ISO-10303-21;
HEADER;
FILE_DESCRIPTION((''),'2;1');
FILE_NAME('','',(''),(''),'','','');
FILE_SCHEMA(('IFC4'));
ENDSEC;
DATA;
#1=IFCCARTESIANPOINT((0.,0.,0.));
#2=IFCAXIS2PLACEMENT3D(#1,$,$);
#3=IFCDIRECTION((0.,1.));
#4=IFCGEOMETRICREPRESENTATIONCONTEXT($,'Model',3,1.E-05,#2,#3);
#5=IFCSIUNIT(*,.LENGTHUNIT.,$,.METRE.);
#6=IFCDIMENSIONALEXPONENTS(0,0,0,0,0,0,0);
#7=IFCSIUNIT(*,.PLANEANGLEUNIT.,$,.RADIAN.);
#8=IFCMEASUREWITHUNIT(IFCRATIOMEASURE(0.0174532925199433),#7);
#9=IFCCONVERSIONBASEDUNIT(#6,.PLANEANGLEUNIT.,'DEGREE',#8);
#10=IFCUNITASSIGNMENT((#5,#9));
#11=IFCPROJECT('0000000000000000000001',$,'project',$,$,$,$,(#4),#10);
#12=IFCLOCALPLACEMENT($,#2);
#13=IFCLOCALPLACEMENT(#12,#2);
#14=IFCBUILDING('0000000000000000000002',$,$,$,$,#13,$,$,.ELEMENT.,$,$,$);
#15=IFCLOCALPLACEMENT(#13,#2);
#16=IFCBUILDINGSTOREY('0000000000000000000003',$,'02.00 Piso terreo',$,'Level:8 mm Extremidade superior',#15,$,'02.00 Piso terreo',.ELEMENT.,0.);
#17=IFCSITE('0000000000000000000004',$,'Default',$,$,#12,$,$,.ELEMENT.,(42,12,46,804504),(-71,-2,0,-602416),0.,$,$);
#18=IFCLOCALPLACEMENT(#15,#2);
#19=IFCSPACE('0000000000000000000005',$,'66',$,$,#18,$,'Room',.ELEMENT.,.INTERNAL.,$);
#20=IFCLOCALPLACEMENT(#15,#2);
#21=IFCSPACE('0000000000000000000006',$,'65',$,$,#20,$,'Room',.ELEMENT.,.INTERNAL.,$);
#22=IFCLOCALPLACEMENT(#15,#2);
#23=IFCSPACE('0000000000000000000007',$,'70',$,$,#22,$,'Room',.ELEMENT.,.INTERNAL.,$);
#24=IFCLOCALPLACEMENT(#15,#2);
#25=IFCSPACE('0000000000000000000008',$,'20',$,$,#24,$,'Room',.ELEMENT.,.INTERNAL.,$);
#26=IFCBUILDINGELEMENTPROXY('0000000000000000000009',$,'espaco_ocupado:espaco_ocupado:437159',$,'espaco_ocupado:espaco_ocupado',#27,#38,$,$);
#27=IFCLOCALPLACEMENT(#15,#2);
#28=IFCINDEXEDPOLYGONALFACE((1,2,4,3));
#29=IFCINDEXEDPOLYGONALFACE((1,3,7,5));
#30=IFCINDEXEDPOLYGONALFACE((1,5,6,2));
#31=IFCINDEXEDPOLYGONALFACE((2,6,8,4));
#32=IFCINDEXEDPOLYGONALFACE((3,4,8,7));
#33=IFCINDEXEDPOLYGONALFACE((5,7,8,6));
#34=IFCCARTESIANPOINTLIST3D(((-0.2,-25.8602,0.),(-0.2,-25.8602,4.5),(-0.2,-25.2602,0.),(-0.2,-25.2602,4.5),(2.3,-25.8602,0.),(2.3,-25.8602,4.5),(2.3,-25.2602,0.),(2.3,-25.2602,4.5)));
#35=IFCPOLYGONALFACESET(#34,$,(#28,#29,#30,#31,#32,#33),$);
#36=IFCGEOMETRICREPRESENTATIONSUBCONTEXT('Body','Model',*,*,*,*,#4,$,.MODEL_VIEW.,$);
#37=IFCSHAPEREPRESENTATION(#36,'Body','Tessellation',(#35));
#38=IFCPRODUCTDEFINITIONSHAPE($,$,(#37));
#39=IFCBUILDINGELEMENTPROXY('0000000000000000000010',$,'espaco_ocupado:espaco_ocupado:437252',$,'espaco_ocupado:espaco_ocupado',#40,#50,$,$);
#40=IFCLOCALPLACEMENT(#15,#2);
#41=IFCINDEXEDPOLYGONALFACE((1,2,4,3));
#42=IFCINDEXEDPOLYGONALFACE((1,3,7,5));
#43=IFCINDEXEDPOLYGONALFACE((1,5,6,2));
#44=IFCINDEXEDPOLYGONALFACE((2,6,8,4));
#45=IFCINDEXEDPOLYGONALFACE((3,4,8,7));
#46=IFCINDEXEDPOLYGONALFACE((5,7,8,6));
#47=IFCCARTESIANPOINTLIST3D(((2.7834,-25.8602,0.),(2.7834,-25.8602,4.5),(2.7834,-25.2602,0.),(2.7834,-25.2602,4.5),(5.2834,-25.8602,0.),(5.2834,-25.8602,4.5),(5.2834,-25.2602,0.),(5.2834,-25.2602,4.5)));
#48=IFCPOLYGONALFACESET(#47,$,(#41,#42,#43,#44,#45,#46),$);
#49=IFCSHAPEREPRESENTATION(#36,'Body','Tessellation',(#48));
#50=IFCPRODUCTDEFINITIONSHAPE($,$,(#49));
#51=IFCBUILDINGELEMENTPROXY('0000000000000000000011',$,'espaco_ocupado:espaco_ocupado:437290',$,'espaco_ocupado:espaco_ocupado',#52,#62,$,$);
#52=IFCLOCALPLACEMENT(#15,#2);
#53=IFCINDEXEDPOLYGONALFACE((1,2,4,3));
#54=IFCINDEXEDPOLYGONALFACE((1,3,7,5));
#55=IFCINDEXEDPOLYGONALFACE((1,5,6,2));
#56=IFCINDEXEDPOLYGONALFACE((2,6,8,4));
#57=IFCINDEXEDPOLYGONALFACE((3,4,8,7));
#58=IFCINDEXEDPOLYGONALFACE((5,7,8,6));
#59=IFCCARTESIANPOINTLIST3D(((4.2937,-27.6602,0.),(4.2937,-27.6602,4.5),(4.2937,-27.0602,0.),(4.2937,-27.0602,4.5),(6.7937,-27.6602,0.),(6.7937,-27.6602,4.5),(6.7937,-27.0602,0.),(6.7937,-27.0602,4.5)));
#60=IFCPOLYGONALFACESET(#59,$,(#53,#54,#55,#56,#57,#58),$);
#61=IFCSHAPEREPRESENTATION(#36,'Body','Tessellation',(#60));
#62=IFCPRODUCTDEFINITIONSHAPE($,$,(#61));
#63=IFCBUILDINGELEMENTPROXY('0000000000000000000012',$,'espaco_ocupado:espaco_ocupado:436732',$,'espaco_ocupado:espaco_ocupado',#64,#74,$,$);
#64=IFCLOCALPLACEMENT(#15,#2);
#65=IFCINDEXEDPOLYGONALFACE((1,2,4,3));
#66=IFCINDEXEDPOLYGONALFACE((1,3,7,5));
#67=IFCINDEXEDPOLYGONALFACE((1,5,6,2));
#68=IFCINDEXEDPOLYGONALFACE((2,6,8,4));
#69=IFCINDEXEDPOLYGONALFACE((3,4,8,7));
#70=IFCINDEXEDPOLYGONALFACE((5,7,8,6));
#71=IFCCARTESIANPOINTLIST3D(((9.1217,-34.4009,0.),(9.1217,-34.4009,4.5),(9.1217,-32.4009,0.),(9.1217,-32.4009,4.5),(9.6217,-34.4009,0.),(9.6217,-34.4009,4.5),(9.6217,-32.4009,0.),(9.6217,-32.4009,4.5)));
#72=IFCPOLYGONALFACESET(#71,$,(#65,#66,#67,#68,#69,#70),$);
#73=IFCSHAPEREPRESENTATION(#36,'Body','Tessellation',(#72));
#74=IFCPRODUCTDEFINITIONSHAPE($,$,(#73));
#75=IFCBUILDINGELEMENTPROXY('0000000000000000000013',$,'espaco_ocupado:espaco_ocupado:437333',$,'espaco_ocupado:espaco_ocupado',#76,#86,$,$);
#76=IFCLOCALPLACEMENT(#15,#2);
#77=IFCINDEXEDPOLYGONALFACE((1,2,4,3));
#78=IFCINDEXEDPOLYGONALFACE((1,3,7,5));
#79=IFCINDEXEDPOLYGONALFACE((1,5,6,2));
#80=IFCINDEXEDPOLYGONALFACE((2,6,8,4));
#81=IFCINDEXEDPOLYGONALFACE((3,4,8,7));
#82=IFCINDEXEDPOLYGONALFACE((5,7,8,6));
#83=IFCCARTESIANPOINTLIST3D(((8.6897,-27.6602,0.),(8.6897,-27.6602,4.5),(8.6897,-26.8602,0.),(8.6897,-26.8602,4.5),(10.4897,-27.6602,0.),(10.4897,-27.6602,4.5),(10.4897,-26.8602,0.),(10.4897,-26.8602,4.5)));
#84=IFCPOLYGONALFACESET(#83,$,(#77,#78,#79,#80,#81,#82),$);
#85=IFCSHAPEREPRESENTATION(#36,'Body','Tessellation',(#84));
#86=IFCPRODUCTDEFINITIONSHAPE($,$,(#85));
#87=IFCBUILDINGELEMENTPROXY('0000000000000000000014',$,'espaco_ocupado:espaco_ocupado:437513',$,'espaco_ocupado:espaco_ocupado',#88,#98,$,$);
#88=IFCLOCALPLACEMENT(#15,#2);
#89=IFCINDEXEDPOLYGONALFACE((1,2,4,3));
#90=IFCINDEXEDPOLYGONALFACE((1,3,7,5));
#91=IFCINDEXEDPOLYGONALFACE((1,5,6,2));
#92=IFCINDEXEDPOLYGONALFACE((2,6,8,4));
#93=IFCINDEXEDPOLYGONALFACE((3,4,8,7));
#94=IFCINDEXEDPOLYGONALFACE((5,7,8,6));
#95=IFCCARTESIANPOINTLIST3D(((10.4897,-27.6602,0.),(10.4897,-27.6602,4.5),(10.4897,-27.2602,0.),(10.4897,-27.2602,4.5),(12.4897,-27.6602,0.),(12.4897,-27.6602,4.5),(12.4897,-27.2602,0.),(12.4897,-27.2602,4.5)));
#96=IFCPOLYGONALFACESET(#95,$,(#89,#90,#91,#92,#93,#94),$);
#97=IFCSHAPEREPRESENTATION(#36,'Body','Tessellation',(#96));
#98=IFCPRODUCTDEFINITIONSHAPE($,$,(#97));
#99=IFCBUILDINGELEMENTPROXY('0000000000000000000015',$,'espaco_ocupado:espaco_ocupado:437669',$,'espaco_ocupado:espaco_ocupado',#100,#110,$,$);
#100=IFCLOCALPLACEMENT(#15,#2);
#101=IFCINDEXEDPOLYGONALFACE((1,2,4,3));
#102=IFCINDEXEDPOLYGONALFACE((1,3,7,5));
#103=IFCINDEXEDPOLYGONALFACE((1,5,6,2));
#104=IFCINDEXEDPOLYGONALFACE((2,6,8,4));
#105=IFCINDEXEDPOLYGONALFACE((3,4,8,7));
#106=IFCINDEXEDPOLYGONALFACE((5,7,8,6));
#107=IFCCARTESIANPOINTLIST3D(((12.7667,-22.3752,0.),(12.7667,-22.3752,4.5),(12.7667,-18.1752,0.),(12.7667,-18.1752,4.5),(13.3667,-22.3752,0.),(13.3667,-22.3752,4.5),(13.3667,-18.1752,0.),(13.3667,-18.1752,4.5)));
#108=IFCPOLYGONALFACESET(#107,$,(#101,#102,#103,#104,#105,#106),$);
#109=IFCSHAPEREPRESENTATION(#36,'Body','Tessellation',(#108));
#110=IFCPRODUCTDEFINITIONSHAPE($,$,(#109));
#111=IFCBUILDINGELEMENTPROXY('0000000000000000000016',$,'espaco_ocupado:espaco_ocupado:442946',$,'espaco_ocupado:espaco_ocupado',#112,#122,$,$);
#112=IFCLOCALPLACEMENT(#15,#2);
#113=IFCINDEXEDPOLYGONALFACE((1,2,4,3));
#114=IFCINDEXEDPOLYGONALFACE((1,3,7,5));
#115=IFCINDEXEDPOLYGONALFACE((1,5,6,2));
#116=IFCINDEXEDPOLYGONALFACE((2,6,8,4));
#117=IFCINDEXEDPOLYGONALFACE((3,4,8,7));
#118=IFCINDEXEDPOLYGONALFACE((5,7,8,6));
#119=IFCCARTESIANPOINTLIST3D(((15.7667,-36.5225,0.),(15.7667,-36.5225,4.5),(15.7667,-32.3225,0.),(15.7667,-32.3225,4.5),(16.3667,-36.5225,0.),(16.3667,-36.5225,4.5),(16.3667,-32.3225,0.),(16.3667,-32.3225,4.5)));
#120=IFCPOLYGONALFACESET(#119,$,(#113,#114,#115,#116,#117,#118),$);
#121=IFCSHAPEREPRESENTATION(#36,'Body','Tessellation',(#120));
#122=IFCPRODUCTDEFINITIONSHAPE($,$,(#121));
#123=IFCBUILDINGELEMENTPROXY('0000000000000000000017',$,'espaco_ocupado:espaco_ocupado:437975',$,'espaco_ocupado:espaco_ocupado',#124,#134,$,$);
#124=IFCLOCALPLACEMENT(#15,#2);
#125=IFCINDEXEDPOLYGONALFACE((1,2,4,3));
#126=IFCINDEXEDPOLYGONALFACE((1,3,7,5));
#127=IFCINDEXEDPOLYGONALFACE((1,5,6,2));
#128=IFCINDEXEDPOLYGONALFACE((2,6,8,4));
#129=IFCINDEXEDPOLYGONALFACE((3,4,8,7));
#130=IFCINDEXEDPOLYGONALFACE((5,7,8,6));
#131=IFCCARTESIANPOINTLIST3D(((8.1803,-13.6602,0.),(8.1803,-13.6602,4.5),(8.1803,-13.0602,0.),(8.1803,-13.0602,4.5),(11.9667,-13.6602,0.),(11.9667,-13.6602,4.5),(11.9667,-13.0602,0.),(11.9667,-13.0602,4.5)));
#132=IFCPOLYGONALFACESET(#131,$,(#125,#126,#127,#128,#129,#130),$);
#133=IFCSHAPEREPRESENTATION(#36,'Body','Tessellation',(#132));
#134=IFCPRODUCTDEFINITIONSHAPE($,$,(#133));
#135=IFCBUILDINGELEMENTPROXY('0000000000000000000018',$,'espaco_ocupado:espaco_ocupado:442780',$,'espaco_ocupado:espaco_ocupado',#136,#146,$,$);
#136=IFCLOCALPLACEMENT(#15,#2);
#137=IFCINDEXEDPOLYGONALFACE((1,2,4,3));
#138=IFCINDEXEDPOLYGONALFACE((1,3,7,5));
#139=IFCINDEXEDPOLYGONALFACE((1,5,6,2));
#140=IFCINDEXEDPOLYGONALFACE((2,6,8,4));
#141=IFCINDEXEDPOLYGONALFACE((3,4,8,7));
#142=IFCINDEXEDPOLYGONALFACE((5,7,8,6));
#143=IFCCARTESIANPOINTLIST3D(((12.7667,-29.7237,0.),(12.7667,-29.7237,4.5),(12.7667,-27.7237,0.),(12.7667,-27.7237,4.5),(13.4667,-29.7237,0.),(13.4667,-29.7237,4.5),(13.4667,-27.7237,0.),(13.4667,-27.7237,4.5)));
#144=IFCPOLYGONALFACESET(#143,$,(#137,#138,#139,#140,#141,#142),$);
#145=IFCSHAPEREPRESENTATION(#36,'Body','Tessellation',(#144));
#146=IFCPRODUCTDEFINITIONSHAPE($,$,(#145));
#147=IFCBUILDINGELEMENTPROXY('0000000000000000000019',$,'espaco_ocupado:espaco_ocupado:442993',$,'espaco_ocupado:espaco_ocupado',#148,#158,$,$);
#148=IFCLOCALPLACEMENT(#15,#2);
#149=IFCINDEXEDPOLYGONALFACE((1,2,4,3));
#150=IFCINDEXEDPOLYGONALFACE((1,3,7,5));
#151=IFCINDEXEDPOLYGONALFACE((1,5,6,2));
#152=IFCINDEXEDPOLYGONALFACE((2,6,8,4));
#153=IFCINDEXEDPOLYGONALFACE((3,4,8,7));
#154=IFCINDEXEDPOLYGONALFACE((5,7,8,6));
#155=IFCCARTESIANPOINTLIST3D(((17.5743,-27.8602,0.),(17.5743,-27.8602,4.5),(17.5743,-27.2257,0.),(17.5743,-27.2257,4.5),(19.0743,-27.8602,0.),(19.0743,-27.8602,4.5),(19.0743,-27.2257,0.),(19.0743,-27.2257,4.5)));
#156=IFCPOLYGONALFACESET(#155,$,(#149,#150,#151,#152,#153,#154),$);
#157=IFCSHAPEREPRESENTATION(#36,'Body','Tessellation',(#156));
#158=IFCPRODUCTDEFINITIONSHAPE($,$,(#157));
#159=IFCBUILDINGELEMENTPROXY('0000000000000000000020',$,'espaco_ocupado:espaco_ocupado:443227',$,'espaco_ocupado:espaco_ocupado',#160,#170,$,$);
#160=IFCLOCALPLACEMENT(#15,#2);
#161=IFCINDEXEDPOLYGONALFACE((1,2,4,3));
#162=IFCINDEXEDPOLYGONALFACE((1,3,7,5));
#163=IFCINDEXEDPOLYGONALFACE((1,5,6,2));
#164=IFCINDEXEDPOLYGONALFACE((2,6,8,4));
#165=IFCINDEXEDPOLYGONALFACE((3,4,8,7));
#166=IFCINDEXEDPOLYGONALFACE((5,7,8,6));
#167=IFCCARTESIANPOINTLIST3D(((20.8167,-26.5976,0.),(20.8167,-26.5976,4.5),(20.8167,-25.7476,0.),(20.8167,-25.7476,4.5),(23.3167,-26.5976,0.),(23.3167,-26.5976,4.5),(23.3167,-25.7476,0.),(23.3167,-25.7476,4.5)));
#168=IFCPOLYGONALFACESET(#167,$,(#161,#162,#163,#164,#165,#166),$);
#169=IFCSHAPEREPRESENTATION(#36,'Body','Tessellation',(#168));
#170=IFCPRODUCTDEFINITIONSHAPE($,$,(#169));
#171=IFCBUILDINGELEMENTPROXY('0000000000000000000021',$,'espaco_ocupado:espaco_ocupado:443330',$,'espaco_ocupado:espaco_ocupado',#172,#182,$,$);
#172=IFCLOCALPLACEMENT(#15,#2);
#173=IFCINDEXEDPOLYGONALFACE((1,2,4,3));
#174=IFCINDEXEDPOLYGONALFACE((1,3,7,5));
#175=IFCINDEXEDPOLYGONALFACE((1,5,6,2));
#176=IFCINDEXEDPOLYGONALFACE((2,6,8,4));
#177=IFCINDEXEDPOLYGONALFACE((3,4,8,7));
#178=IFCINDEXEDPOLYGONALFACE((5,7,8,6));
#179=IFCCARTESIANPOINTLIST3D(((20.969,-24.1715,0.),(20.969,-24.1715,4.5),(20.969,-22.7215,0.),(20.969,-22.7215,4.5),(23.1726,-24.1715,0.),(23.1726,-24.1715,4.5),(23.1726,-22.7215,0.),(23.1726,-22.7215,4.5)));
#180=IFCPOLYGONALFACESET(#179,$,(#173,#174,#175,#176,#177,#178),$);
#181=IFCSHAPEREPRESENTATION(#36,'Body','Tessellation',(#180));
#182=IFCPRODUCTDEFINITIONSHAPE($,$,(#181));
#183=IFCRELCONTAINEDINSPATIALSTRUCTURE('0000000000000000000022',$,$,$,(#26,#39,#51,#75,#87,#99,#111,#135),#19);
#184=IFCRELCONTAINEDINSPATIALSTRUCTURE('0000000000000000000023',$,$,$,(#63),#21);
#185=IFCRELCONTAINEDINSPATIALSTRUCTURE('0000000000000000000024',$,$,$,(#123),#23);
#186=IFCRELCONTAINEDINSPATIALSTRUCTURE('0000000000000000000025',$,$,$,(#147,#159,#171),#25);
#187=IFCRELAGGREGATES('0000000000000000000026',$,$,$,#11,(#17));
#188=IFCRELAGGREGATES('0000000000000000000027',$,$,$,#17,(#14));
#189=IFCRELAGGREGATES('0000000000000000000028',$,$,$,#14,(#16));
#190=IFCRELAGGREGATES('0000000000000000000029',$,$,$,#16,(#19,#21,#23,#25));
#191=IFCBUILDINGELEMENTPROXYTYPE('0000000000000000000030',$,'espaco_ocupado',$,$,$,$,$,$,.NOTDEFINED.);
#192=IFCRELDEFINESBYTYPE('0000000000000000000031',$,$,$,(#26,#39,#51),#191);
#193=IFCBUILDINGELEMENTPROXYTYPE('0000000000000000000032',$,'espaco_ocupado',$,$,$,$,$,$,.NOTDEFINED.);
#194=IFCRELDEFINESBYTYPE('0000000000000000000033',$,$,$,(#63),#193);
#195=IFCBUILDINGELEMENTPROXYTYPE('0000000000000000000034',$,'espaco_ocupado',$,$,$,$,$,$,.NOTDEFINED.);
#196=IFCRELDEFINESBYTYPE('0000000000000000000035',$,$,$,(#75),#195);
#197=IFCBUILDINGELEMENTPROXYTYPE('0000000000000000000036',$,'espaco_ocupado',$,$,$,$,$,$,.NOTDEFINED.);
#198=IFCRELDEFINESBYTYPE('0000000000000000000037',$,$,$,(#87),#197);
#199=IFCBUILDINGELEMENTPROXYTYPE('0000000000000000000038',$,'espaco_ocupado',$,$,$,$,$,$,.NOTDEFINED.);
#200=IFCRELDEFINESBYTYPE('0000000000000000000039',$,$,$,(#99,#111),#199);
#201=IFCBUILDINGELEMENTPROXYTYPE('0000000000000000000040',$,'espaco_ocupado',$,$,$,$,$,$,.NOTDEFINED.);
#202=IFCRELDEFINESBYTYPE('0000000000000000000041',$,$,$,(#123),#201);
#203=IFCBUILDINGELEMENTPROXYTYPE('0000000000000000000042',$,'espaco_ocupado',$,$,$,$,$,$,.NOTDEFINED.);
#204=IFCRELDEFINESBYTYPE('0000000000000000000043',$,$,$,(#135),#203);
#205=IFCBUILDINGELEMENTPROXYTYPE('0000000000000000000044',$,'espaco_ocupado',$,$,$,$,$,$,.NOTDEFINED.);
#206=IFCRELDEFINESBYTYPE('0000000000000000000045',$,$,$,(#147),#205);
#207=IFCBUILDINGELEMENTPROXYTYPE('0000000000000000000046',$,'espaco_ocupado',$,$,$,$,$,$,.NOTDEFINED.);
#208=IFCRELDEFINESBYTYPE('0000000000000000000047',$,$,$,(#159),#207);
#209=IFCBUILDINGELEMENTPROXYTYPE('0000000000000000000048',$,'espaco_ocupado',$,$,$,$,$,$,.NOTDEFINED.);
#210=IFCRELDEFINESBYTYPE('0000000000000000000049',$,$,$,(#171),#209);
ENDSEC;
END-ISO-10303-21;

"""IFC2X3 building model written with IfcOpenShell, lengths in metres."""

from ifc_helpers import new_model, entity, si_unit, converted_unit, direction, frame, origin, origin_2d_with_axis, place, context, subcontext, project, spatial, rectangle, extrude, source, transform, mapped, type_object, type_shapes, element, save


model = new_model("IFC2X3")

# Units and contexts
model_context = context("Model", 3, precision=1e-05, world=origin(), true_north=direction((0.0, 1.0)))
body_context = subcontext(model_context, "Body", "Model", "MODEL_VIEW")
ifc_project = project(units=[si_unit("LENGTHUNIT", "METRE"), converted_unit("PLANEANGLEUNIT", "DEGREE", entity("IfcRatioMeasure", 0.0174532925199433), si_unit("PLANEANGLEUNIT", "RADIAN"), dimensions=[0, 0, 0, 0, 0, 0, 0])], contexts=[model_context])

# Site, building, storey
site_placement = place(None, origin())
site = spatial("IfcSite", under=ifc_project, at=site_placement, Name="Default", CompositionType="ELEMENT", RefLatitude=(42, 12, 46, 804504), RefLongitude=(-71, -2, 0, -602416), RefElevation=0.0)
building_placement = place(site_placement, origin())
building = spatial("IfcBuilding", under=site, at=building_placement, CompositionType="ELEMENT")
storey_placement = place(building_placement, origin())
storey = spatial("IfcBuildingStorey", under=building, at=storey_placement, Name="02.00 Piso terreo", ObjectType="Level:8 mm Extremidade superior", LongName="02.00 Piso terreo", CompositionType="ELEMENT", Elevation=0.0)

# Shared definitions
space_1_placement = place(storey_placement, origin())
space_1 = spatial("IfcSpace", under=storey, at=space_1_placement, Name="66", LongName="Room", CompositionType="ELEMENT", InteriorOrExteriorSpace="INTERNAL")

# Building element proxies
building_element_proxy_type_1 = type_object("IfcBuildingElementProxyType", Name="espaco_ocupado", PredefinedType="NOTDEFINED")
shared_shape_1 = source(origin(), body_context, "Body", "SweptSolid", [
    extrude(rectangle(XDim=2.5, YDim=0.6, at=origin_2d_with_axis()), frame((0.0, 0.0, 0.0), z_axis=(0.0, 0.0, 1.0), x_axis=(-1.0, 0.0, 0.0)), (0.0, 0.0, 1.0), 4.5),
])
type_shapes(building_element_proxy_type_1, [shared_shape_1])
for number, where, name in (
    (1, (1.05, -25.5602, 0.0), "espaco_ocupado:espaco_ocupado:437159"),
    (2, (4.0334, -25.5602, 0.0), "espaco_ocupado:espaco_ocupado:437252"),
    (3, (5.5437, -27.3602, 0.0), "espaco_ocupado:espaco_ocupado:437290"),
):
    element("IfcBuildingElementProxy", number, at=place(space_1_placement, frame(where)), inside=space_1, type_object=building_element_proxy_type_1, Name=name, ObjectType="espaco_ocupado:espaco_ocupado", context=body_context, shape_type="MappedRepresentation", body=[
        mapped(shared_shape_1, transform((0.0, 0.0, 0.0), scale=1.0)),
    ])

# Shared definitions
space_2_placement = place(storey_placement, origin())
space_2 = spatial("IfcSpace", under=storey, at=space_2_placement, Name="65", LongName="Room", CompositionType="ELEMENT", InteriorOrExteriorSpace="INTERNAL")

# Building element proxies
building_element_proxy_type_2 = type_object("IfcBuildingElementProxyType", Name="espaco_ocupado", PredefinedType="NOTDEFINED")
shared_shape_2 = source(origin(), body_context, "Body", "SweptSolid", [
    extrude(rectangle(XDim=2.0, YDim=0.5, at=origin_2d_with_axis()), frame((0.0, 0.0, 0.0), z_axis=(0.0, 0.0, 1.0), x_axis=(-1.0, 0.0, 0.0)), (0.0, 0.0, 1.0), 4.5),
])
type_shapes(building_element_proxy_type_2, [shared_shape_2])
proxy_1_placement = place(space_2_placement, frame((9.3717, -33.4009, 0.0), z_axis=(0.0, 0.0, 1.0), x_axis=(0.0, 1.0, 0.0)))
element("IfcBuildingElementProxy", 4, at=proxy_1_placement, inside=space_2, type_object=building_element_proxy_type_2, Name="espaco_ocupado:espaco_ocupado:436732", ObjectType="espaco_ocupado:espaco_ocupado", context=body_context, shape_type="MappedRepresentation", body=[
    mapped(shared_shape_2, transform((0.0, 0.0, 0.0), scale=1.0)),
])
building_element_proxy_type_3 = type_object("IfcBuildingElementProxyType", Name="espaco_ocupado", PredefinedType="NOTDEFINED")
shared_shape_3 = source(origin(), body_context, "Body", "SweptSolid", [
    extrude(rectangle(XDim=1.8, YDim=0.8, at=origin_2d_with_axis()), frame((0.0, 0.0, 0.0), z_axis=(0.0, 0.0, 1.0), x_axis=(-1.0, 0.0, 0.0)), (0.0, 0.0, 1.0), 4.5),
])
type_shapes(building_element_proxy_type_3, [shared_shape_3])
proxy_2_placement = place(space_1_placement, frame((9.5897, -27.2602, 0.0)))
element("IfcBuildingElementProxy", 5, at=proxy_2_placement, inside=space_1, type_object=building_element_proxy_type_3, Name="espaco_ocupado:espaco_ocupado:437333", ObjectType="espaco_ocupado:espaco_ocupado", context=body_context, shape_type="MappedRepresentation", body=[
    mapped(shared_shape_3, transform((0.0, 0.0, 0.0), scale=1.0)),
])
building_element_proxy_type_4 = type_object("IfcBuildingElementProxyType", Name="espaco_ocupado", PredefinedType="NOTDEFINED")
shared_shape_4 = source(origin(), body_context, "Body", "SweptSolid", [
    extrude(rectangle(XDim=2.0, YDim=0.4, at=origin_2d_with_axis()), frame((0.0, 0.0, 0.0), z_axis=(0.0, 0.0, 1.0), x_axis=(-1.0, 0.0, 0.0)), (0.0, 0.0, 1.0), 4.5),
])
type_shapes(building_element_proxy_type_4, [shared_shape_4])
proxy_3_placement = place(space_1_placement, frame((11.4897, -27.4602, 0.0)))
element("IfcBuildingElementProxy", 6, at=proxy_3_placement, inside=space_1, type_object=building_element_proxy_type_4, Name="espaco_ocupado:espaco_ocupado:437513", ObjectType="espaco_ocupado:espaco_ocupado", context=body_context, shape_type="MappedRepresentation", body=[
    mapped(shared_shape_4, transform((0.0, 0.0, 0.0), scale=1.0)),
])
building_element_proxy_type_5 = type_object("IfcBuildingElementProxyType", Name="espaco_ocupado", PredefinedType="NOTDEFINED")
shared_shape_5 = source(origin(), body_context, "Body", "SweptSolid", [
    extrude(rectangle(XDim=4.2, YDim=0.6, at=origin_2d_with_axis()), frame((0.0, 0.0, 0.0), z_axis=(0.0, 0.0, 1.0), x_axis=(-1.0, 0.0, 0.0)), (0.0, 0.0, 1.0), 4.5),
])
type_shapes(building_element_proxy_type_5, [shared_shape_5])
for number, where, z_axis, x_axis, name in (
    (7, (13.0667, -20.2752, 0.0), (0.0, 0.0, 1.0), (0.0, -1.0, 0.0), "espaco_ocupado:espaco_ocupado:437669"),
    (8, (16.0667, -34.4225, 0.0), (0.0, 0.0, 1.0), (0.0, -1.0, 0.0), "espaco_ocupado:espaco_ocupado:442946"),
):
    element("IfcBuildingElementProxy", number, at=place(space_1_placement, frame(where, z_axis=z_axis, x_axis=x_axis)), inside=space_1, type_object=building_element_proxy_type_5, Name=name, ObjectType="espaco_ocupado:espaco_ocupado", context=body_context, shape_type="MappedRepresentation", body=[
        mapped(shared_shape_5, transform((0.0, 0.0, 0.0), scale=1.0)),
    ])

# Shared definitions
space_3_placement = place(storey_placement, origin())
space_3 = spatial("IfcSpace", under=storey, at=space_3_placement, Name="70", LongName="Room", CompositionType="ELEMENT", InteriorOrExteriorSpace="INTERNAL")

# Building element proxies
building_element_proxy_type_6 = type_object("IfcBuildingElementProxyType", Name="espaco_ocupado", PredefinedType="NOTDEFINED")
shared_shape_6 = source(origin(), body_context, "Body", "SweptSolid", [
    extrude(rectangle(XDim=3.7864, YDim=0.6, at=origin_2d_with_axis()), frame((0.0, 0.0, 0.0), z_axis=(0.0, 0.0, 1.0), x_axis=(-1.0, 0.0, 0.0)), (0.0, 0.0, 1.0), 4.5),
])
type_shapes(building_element_proxy_type_6, [shared_shape_6])
proxy_4_placement = place(space_3_placement, frame((10.0735, -13.3602, 0.0)))
element("IfcBuildingElementProxy", 9, at=proxy_4_placement, inside=space_3, type_object=building_element_proxy_type_6, Name="espaco_ocupado:espaco_ocupado:437975", ObjectType="espaco_ocupado:espaco_ocupado", context=body_context, shape_type="MappedRepresentation", body=[
    mapped(shared_shape_6, transform((0.0, 0.0, 0.0), scale=1.0)),
])
building_element_proxy_type_7 = type_object("IfcBuildingElementProxyType", Name="espaco_ocupado", PredefinedType="NOTDEFINED")
shared_shape_7 = source(origin(), body_context, "Body", "SweptSolid", [
    extrude(rectangle(XDim=0.7, YDim=2.0, at=origin_2d_with_axis()), frame((0.0, 0.0, 0.0), z_axis=(0.0, 0.0, 1.0), x_axis=(-1.0, 0.0, 0.0)), (0.0, 0.0, 1.0), 4.5),
])
type_shapes(building_element_proxy_type_7, [shared_shape_7])
proxy_5_placement = place(space_1_placement, frame((13.1167, -28.7237, 0.0)))
element("IfcBuildingElementProxy", 10, at=proxy_5_placement, inside=space_1, type_object=building_element_proxy_type_7, Name="espaco_ocupado:espaco_ocupado:442780", ObjectType="espaco_ocupado:espaco_ocupado", context=body_context, shape_type="MappedRepresentation", body=[
    mapped(shared_shape_7, transform((0.0, 0.0, 0.0), scale=1.0)),
])

# Shared definitions
space_4_placement = place(storey_placement, origin())
space_4 = spatial("IfcSpace", under=storey, at=space_4_placement, Name="20", LongName="Room", CompositionType="ELEMENT", InteriorOrExteriorSpace="INTERNAL")

# Building element proxies
building_element_proxy_type_8 = type_object("IfcBuildingElementProxyType", Name="espaco_ocupado", PredefinedType="NOTDEFINED")
shared_shape_8 = source(origin(), body_context, "Body", "SweptSolid", [
    extrude(rectangle(XDim=1.5, YDim=0.6345, at=origin_2d_with_axis()), frame((0.0, 0.0, 0.0), z_axis=(0.0, 0.0, 1.0), x_axis=(-1.0, 0.0, 0.0)), (0.0, 0.0, 1.0), 4.5),
])
type_shapes(building_element_proxy_type_8, [shared_shape_8])
proxy_6_placement = place(space_4_placement, frame((18.3243, -27.5429, 0.0)))
element("IfcBuildingElementProxy", 11, at=proxy_6_placement, inside=space_4, type_object=building_element_proxy_type_8, Name="espaco_ocupado:espaco_ocupado:442993", ObjectType="espaco_ocupado:espaco_ocupado", context=body_context, shape_type="MappedRepresentation", body=[
    mapped(shared_shape_8, transform((0.0, 0.0, 0.0), scale=1.0)),
])
building_element_proxy_type_9 = type_object("IfcBuildingElementProxyType", Name="espaco_ocupado", PredefinedType="NOTDEFINED")
shared_shape_9 = source(origin(), body_context, "Body", "SweptSolid", [
    extrude(rectangle(XDim=2.5, YDim=0.85, at=origin_2d_with_axis()), frame((0.0, 0.0, 0.0), z_axis=(0.0, 0.0, 1.0), x_axis=(-1.0, 0.0, 0.0)), (0.0, 0.0, 1.0), 4.5),
])
type_shapes(building_element_proxy_type_9, [shared_shape_9])
proxy_7_placement = place(space_4_placement, frame((22.0667, -26.1726, 0.0)))
element("IfcBuildingElementProxy", 12, at=proxy_7_placement, inside=space_4, type_object=building_element_proxy_type_9, Name="espaco_ocupado:espaco_ocupado:443227", ObjectType="espaco_ocupado:espaco_ocupado", context=body_context, shape_type="MappedRepresentation", body=[
    mapped(shared_shape_9, transform((0.0, 0.0, 0.0), scale=1.0)),
])
building_element_proxy_type_10 = type_object("IfcBuildingElementProxyType", Name="espaco_ocupado", PredefinedType="NOTDEFINED")
shared_shape_10 = source(origin(), body_context, "Body", "SweptSolid", [
    extrude(rectangle(XDim=2.2036, YDim=1.45, at=origin_2d_with_axis()), frame((0.0, 0.0, 0.0), z_axis=(0.0, 0.0, 1.0), x_axis=(-1.0, 0.0, 0.0)), (0.0, 0.0, 1.0), 4.5),
])
type_shapes(building_element_proxy_type_10, [shared_shape_10])
proxy_8_placement = place(space_4_placement, frame((22.0708, -23.4465, 0.0)))
element("IfcBuildingElementProxy", 13, at=proxy_8_placement, inside=space_4, type_object=building_element_proxy_type_10, Name="espaco_ocupado:espaco_ocupado:443330", ObjectType="espaco_ocupado:espaco_ocupado", context=body_context, shape_type="MappedRepresentation", body=[
    mapped(shared_shape_10, transform((0.0, 0.0, 0.0), scale=1.0)),
])

save(model, "model.ifc")
